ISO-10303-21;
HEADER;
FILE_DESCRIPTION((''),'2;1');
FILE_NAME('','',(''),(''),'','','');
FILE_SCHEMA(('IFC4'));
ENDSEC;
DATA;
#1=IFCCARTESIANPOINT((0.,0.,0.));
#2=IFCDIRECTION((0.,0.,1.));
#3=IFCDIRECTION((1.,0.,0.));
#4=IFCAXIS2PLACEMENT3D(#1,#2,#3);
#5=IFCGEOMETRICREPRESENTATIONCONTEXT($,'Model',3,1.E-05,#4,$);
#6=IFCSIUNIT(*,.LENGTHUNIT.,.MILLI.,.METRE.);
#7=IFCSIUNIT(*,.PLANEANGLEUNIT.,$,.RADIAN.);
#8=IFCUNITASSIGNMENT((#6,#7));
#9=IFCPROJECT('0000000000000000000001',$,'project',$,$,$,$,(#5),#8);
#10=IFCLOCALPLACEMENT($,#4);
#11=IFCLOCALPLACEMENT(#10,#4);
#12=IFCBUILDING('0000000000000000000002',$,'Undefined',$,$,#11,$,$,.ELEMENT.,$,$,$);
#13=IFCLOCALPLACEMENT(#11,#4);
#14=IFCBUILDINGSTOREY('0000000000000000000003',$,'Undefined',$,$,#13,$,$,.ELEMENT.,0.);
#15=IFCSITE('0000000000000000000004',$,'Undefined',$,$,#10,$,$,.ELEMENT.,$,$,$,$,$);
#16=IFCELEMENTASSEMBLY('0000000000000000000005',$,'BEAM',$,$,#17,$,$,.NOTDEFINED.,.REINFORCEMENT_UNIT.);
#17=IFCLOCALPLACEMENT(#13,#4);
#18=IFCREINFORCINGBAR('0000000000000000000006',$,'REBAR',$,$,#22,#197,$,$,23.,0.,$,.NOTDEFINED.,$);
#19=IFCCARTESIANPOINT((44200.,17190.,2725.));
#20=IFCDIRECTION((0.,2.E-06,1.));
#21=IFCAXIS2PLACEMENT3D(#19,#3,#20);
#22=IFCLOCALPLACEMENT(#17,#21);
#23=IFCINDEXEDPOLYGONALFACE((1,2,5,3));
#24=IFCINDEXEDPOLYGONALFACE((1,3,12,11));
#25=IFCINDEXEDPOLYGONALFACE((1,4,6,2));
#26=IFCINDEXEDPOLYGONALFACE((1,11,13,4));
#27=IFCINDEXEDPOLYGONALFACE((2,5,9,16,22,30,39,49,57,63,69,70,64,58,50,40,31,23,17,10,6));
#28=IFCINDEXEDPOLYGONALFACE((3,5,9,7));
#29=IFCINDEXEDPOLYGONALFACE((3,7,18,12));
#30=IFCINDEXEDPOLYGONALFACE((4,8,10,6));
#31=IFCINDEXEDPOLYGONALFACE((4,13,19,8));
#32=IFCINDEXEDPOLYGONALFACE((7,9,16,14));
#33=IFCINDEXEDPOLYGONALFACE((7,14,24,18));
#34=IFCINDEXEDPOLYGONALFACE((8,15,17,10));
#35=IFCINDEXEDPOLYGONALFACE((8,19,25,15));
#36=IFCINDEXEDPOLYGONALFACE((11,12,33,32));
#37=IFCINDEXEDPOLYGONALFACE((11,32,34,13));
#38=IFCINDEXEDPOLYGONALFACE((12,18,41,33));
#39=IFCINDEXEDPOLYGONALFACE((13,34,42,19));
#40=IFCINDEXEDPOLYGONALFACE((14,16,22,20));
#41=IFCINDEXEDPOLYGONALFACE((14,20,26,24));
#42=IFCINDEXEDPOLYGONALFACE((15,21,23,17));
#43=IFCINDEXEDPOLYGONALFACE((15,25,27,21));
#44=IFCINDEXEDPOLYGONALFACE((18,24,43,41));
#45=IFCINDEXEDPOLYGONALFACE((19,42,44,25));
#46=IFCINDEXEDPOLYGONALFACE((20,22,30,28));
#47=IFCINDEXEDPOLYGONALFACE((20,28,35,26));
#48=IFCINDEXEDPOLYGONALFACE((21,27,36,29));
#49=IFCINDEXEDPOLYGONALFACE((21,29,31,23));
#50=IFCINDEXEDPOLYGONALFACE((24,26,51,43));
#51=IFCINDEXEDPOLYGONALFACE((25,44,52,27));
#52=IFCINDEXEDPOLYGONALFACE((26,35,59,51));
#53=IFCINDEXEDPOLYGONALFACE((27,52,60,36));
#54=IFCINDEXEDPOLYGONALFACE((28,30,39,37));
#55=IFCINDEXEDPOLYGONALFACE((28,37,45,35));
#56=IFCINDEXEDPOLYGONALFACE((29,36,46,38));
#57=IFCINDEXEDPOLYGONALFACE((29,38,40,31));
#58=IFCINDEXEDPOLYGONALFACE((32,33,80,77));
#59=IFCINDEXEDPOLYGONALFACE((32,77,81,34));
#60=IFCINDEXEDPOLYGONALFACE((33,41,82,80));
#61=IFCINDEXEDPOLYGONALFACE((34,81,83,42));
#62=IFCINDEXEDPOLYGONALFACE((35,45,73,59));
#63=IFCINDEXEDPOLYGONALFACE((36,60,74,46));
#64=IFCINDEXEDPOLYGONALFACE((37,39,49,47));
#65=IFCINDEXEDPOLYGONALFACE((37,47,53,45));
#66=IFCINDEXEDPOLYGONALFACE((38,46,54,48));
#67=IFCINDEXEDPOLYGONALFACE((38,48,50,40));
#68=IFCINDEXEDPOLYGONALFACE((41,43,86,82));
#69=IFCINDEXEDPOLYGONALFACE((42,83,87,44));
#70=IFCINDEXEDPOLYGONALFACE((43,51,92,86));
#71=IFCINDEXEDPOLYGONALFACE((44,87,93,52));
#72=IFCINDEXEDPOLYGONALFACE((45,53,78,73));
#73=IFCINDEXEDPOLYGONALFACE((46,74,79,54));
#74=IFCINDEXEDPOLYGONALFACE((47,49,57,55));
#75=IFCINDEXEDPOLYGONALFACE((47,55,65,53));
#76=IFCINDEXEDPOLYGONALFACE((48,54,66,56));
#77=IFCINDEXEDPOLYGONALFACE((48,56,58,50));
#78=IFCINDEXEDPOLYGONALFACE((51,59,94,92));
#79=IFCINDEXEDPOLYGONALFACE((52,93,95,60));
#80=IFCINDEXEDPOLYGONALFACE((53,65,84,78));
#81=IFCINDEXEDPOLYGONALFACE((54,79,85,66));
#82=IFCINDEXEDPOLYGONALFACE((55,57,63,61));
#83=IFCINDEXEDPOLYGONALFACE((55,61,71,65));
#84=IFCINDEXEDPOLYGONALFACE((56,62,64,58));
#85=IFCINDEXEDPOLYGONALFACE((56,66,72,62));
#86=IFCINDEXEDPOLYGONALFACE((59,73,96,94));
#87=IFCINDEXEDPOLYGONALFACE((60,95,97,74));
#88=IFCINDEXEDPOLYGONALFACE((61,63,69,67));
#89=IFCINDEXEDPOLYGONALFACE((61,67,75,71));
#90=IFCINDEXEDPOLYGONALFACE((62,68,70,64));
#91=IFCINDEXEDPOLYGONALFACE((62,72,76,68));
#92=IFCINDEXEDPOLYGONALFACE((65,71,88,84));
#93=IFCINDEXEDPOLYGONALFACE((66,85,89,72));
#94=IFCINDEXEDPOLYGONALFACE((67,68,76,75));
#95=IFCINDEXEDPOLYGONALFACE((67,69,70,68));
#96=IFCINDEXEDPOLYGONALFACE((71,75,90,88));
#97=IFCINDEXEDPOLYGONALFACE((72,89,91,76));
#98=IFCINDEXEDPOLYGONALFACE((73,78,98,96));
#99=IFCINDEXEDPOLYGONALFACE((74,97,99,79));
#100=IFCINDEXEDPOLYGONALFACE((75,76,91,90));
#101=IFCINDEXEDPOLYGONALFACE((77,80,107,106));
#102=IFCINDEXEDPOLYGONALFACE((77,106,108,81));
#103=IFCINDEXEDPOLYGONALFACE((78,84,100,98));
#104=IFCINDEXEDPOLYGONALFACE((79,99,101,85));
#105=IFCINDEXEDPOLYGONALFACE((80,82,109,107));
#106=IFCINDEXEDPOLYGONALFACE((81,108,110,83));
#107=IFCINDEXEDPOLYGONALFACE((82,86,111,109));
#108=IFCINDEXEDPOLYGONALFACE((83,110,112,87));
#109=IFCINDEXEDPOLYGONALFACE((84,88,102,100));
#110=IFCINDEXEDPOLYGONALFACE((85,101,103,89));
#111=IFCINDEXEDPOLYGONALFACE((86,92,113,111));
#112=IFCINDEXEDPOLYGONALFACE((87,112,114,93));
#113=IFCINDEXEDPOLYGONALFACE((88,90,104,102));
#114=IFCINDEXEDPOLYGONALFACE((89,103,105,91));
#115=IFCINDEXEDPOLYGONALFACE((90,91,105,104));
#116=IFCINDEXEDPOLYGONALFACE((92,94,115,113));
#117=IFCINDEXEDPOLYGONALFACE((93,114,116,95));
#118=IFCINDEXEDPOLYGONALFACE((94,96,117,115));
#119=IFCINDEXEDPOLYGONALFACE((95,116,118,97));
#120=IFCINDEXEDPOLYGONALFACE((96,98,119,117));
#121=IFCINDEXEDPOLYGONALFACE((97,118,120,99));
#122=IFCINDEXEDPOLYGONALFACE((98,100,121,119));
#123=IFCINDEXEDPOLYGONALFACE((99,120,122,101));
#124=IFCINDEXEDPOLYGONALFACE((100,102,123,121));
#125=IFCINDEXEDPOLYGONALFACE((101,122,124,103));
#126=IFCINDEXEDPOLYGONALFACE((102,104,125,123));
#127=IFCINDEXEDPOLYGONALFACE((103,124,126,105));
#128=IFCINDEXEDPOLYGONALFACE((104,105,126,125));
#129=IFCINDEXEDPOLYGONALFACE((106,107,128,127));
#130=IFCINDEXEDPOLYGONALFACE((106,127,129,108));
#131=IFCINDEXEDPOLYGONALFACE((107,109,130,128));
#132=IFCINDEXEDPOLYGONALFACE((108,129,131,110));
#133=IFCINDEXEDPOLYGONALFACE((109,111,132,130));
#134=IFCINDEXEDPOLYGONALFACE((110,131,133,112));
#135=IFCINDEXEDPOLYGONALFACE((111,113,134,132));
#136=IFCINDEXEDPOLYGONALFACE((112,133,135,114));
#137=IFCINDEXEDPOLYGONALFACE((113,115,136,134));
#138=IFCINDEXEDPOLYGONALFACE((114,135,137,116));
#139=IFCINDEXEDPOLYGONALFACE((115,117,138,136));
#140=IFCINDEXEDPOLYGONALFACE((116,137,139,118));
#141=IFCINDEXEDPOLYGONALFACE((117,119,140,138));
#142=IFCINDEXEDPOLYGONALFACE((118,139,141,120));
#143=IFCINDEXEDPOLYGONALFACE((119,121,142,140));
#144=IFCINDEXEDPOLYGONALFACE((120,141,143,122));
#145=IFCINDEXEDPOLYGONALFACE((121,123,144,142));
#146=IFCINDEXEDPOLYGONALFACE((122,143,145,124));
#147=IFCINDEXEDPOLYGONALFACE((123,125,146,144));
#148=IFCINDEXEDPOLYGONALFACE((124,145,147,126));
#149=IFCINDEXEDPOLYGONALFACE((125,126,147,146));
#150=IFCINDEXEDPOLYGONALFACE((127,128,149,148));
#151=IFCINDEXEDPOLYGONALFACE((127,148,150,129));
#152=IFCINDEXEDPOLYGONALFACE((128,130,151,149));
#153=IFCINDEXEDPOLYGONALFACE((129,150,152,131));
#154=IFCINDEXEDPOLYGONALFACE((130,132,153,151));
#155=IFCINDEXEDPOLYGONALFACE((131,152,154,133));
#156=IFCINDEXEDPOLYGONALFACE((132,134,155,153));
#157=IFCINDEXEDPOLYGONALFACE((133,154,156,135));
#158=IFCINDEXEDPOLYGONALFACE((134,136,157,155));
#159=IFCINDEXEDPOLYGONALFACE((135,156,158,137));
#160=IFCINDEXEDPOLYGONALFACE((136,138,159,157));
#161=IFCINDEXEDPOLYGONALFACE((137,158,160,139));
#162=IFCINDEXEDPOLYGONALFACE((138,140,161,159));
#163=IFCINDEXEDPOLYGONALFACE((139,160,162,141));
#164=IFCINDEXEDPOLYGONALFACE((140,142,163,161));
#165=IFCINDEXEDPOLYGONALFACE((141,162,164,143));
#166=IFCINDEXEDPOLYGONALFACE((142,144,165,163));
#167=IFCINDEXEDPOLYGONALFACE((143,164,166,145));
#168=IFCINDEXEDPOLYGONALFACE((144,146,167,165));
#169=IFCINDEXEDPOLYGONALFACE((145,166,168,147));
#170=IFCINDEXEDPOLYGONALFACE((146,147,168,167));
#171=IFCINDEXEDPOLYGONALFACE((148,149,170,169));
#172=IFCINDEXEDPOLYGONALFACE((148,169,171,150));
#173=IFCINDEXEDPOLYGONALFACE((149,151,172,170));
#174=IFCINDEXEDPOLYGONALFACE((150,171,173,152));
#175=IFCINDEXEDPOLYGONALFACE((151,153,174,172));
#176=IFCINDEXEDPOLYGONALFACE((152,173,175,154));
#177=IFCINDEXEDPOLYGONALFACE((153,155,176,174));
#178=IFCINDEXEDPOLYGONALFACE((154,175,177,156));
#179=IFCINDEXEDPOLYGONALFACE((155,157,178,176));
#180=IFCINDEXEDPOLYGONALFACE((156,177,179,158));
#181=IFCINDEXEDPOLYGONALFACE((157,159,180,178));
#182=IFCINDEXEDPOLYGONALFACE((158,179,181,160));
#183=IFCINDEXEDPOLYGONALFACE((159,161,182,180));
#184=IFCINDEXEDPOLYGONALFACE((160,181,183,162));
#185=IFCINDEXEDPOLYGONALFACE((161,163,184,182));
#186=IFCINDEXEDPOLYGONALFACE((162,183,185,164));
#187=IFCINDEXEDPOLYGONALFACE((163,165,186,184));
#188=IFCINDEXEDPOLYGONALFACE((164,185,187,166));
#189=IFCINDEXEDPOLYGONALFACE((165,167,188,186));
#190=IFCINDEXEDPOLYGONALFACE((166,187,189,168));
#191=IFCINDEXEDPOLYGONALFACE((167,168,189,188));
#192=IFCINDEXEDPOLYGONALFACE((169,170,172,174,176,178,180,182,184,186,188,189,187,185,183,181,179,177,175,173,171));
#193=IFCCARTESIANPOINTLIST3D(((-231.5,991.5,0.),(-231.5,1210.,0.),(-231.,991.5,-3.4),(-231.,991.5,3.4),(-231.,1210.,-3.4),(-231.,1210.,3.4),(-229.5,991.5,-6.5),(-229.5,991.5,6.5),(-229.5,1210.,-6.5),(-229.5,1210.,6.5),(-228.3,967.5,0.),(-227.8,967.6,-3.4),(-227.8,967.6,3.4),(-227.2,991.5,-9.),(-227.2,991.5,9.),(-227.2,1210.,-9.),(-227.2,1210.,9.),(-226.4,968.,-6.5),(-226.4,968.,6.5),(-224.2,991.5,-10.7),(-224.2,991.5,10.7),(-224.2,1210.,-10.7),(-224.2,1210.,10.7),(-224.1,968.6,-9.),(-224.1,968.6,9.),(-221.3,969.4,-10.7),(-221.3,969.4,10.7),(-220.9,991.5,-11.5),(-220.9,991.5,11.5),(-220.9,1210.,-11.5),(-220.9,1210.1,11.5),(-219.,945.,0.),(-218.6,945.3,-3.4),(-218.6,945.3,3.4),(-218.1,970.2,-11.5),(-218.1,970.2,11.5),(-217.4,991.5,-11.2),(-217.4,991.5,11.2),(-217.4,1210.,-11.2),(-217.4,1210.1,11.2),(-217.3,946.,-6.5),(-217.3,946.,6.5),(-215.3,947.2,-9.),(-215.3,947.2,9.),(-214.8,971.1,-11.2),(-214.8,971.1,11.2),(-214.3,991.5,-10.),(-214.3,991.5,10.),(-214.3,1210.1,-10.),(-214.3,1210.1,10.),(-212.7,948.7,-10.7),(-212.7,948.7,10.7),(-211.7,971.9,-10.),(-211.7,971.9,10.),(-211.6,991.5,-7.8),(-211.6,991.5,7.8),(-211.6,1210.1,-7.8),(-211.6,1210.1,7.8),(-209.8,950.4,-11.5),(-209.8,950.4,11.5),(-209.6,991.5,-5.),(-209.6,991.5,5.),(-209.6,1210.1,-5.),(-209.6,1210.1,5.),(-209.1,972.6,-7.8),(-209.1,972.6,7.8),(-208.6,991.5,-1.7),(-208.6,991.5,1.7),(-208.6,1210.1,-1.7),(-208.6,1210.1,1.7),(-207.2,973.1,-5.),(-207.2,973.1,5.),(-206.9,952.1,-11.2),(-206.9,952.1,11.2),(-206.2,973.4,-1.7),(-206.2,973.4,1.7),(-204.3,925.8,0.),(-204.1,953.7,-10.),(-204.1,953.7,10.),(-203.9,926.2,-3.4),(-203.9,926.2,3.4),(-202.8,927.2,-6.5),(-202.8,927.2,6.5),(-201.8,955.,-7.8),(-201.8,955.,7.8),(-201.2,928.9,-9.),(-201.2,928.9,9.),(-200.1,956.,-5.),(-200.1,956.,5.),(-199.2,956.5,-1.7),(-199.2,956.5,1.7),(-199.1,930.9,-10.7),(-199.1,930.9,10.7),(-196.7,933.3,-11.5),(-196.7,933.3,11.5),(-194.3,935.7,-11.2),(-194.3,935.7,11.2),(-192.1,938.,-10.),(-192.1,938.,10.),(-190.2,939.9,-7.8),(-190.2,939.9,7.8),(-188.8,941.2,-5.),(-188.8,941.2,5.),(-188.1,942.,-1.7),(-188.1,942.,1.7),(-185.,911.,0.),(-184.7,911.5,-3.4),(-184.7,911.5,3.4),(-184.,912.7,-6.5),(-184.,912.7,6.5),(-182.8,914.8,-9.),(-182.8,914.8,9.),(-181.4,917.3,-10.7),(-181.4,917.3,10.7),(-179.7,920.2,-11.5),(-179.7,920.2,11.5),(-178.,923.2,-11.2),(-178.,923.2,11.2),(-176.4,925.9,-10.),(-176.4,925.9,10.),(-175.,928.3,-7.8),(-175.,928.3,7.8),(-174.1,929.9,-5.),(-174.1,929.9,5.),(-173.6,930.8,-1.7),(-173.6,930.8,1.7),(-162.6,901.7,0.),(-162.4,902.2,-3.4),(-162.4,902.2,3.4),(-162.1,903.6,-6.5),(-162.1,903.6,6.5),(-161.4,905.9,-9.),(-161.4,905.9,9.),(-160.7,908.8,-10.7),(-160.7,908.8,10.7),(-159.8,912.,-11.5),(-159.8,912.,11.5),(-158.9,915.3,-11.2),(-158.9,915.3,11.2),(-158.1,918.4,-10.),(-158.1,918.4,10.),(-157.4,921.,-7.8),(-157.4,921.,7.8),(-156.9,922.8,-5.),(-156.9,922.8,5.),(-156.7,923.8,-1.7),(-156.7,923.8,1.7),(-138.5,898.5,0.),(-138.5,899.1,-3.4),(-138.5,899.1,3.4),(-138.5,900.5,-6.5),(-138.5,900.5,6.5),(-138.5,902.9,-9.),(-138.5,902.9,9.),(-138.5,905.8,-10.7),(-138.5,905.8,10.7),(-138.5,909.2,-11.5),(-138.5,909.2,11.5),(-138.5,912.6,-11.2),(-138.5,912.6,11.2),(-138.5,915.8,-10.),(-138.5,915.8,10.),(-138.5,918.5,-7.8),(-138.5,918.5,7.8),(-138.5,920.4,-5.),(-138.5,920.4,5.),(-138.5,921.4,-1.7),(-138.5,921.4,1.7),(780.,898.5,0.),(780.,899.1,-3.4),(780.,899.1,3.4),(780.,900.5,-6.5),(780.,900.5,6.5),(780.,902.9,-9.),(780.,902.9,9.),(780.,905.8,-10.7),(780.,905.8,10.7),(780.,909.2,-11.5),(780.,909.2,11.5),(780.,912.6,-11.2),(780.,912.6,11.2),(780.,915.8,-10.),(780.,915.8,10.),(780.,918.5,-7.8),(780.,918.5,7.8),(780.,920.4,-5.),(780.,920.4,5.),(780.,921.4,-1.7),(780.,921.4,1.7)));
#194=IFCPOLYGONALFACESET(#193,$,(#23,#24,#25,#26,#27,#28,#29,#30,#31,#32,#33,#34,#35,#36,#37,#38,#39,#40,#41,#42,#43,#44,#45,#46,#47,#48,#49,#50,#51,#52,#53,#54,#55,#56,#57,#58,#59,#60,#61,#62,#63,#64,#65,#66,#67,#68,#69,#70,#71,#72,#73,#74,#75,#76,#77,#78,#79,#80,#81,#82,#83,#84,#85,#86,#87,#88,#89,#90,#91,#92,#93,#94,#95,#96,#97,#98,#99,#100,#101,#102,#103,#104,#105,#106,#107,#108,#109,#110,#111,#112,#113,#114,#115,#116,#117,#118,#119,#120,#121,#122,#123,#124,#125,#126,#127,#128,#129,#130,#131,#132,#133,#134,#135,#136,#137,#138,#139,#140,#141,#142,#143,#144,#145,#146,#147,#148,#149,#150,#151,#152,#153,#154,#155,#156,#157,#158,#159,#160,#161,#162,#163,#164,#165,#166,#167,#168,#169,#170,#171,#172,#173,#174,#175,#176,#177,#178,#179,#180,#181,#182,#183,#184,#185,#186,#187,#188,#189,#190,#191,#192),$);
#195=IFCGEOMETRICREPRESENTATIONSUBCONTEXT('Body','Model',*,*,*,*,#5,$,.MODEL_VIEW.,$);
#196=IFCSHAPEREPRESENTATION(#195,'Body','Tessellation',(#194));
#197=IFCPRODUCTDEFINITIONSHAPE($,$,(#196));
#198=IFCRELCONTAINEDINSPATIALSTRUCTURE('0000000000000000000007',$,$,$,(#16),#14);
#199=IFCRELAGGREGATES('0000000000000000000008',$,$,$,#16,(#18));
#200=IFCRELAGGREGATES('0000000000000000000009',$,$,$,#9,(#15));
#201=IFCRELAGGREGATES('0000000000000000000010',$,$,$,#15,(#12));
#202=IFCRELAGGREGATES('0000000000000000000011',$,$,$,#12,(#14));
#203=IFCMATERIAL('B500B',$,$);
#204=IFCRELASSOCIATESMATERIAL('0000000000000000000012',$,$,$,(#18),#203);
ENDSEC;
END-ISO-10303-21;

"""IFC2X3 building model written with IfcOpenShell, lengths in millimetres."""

from ifc_helpers import new_model, entity, si_unit, frame, origin_with_axes, place, context, subcontext, project, spatial, source, transform, mapped, material, element, aggregate, save


model = new_model("IFC2X3")

# Units and contexts
model_context = context("Model", 3, precision=1e-05, world=origin_with_axes())
body_context = subcontext(model_context, "Body", "Model", "MODEL_VIEW")
ifc_project = project(units=[si_unit("LENGTHUNIT", "METRE", prefix="MILLI"), si_unit("PLANEANGLEUNIT", "RADIAN")], contexts=[model_context])

# Site, building, storey
site_placement = place(None, origin_with_axes())
site = spatial("IfcSite", under=ifc_project, at=site_placement, Name="Undefined", CompositionType="ELEMENT")
building_placement = place(site_placement, origin_with_axes())
building = spatial("IfcBuilding", under=site, at=building_placement, Name="Undefined", CompositionType="ELEMENT")
storey_placement = place(building_placement, origin_with_axes())
storey = spatial("IfcBuildingStorey", under=building, at=storey_placement, Name="Undefined", CompositionType="ELEMENT", Elevation=0.0)

# Shared definitions
ifc_material_1 = material(Name="B500B")

# Element assembly, reinforcing bar
assembly_1_placement = place(storey_placement, origin_with_axes())
assembly_1 = element("IfcElementAssembly", 1, at=assembly_1_placement, inside=storey, Name="BEAM", AssemblyPlace="NOTDEFINED", PredefinedType="REINFORCEMENT_UNIT")
shared_shape_1 = source(origin_with_axes(), body_context, "Body", "AdvancedSweptSolid", [
    entity("IfcSweptDiskSolid", entity("IfcCompositeCurve", [entity("IfcCompositeCurveSegment", "CONTINUOUS", True, entity("IfcTrimmedCurve", entity("IfcLine", entity("IfcCartesianPoint", [0.0, 0.0, 0.0]), entity("IfcVector", entity("IfcDirection", [0.000003, -1.0, 0.000001]), 1.0)), [entity("IfcParameterValue", 0.0)], [entity("IfcParameterValue", 218.500252)], True, "PARAMETER")), entity("IfcCompositeCurveSegment", "CONTINUOUS", True, entity("IfcTrimmedCurve", entity("IfcCircle", entity("IfcAxis2Placement3D", entity("IfcCartesianPoint", [81.5, -218.5, 0.0]), entity("IfcDirection", [0.0, 0.000002, 1.0]), entity("IfcDirection", [-1.0, -0.000003, 0.0])), 81.5), [entity("IfcParameterValue", 0.0)], [entity("IfcParameterValue", 1.570793)], True, "PARAMETER")), entity("IfcCompositeCurveSegment", "DISCONTINUOUS", True, entity("IfcTrimmedCurve", entity("IfcLine", entity("IfcCartesianPoint", [81.5, -300.0, 0.0]), entity("IfcVector", entity("IfcDirection", [1.0, 0.0, 0.0]), 1.0)), [entity("IfcParameterValue", 0.0)], [entity("IfcParameterValue", 918.500252)], True, "PARAMETER"))], False), 11.5, None, 0.0, 1138.6),
])
reinforcing_bar_1_placement = place(assembly_1_placement, frame((44200.0, 17190.0, 2725.0), z_axis=(1.0, 0.0, 0.0), x_axis=(0.0, 0.000002, 1.0)))
reinforcing_bar_1 = element("IfcReinforcingBar", 2, at=reinforcing_bar_1_placement, material=ifc_material_1, Name="REBAR", BarRole="NOTDEFINED", CrossSectionArea=0.0, NominalDiameter=23.0, context=body_context, shape_type="MappedRepresentation", body=[
    mapped(shared_shape_1, transform((-220.0, 1210.0, 0.0))),
])
aggregate(assembly_1, [reinforcing_bar_1])

save(model, "model.ifc")
